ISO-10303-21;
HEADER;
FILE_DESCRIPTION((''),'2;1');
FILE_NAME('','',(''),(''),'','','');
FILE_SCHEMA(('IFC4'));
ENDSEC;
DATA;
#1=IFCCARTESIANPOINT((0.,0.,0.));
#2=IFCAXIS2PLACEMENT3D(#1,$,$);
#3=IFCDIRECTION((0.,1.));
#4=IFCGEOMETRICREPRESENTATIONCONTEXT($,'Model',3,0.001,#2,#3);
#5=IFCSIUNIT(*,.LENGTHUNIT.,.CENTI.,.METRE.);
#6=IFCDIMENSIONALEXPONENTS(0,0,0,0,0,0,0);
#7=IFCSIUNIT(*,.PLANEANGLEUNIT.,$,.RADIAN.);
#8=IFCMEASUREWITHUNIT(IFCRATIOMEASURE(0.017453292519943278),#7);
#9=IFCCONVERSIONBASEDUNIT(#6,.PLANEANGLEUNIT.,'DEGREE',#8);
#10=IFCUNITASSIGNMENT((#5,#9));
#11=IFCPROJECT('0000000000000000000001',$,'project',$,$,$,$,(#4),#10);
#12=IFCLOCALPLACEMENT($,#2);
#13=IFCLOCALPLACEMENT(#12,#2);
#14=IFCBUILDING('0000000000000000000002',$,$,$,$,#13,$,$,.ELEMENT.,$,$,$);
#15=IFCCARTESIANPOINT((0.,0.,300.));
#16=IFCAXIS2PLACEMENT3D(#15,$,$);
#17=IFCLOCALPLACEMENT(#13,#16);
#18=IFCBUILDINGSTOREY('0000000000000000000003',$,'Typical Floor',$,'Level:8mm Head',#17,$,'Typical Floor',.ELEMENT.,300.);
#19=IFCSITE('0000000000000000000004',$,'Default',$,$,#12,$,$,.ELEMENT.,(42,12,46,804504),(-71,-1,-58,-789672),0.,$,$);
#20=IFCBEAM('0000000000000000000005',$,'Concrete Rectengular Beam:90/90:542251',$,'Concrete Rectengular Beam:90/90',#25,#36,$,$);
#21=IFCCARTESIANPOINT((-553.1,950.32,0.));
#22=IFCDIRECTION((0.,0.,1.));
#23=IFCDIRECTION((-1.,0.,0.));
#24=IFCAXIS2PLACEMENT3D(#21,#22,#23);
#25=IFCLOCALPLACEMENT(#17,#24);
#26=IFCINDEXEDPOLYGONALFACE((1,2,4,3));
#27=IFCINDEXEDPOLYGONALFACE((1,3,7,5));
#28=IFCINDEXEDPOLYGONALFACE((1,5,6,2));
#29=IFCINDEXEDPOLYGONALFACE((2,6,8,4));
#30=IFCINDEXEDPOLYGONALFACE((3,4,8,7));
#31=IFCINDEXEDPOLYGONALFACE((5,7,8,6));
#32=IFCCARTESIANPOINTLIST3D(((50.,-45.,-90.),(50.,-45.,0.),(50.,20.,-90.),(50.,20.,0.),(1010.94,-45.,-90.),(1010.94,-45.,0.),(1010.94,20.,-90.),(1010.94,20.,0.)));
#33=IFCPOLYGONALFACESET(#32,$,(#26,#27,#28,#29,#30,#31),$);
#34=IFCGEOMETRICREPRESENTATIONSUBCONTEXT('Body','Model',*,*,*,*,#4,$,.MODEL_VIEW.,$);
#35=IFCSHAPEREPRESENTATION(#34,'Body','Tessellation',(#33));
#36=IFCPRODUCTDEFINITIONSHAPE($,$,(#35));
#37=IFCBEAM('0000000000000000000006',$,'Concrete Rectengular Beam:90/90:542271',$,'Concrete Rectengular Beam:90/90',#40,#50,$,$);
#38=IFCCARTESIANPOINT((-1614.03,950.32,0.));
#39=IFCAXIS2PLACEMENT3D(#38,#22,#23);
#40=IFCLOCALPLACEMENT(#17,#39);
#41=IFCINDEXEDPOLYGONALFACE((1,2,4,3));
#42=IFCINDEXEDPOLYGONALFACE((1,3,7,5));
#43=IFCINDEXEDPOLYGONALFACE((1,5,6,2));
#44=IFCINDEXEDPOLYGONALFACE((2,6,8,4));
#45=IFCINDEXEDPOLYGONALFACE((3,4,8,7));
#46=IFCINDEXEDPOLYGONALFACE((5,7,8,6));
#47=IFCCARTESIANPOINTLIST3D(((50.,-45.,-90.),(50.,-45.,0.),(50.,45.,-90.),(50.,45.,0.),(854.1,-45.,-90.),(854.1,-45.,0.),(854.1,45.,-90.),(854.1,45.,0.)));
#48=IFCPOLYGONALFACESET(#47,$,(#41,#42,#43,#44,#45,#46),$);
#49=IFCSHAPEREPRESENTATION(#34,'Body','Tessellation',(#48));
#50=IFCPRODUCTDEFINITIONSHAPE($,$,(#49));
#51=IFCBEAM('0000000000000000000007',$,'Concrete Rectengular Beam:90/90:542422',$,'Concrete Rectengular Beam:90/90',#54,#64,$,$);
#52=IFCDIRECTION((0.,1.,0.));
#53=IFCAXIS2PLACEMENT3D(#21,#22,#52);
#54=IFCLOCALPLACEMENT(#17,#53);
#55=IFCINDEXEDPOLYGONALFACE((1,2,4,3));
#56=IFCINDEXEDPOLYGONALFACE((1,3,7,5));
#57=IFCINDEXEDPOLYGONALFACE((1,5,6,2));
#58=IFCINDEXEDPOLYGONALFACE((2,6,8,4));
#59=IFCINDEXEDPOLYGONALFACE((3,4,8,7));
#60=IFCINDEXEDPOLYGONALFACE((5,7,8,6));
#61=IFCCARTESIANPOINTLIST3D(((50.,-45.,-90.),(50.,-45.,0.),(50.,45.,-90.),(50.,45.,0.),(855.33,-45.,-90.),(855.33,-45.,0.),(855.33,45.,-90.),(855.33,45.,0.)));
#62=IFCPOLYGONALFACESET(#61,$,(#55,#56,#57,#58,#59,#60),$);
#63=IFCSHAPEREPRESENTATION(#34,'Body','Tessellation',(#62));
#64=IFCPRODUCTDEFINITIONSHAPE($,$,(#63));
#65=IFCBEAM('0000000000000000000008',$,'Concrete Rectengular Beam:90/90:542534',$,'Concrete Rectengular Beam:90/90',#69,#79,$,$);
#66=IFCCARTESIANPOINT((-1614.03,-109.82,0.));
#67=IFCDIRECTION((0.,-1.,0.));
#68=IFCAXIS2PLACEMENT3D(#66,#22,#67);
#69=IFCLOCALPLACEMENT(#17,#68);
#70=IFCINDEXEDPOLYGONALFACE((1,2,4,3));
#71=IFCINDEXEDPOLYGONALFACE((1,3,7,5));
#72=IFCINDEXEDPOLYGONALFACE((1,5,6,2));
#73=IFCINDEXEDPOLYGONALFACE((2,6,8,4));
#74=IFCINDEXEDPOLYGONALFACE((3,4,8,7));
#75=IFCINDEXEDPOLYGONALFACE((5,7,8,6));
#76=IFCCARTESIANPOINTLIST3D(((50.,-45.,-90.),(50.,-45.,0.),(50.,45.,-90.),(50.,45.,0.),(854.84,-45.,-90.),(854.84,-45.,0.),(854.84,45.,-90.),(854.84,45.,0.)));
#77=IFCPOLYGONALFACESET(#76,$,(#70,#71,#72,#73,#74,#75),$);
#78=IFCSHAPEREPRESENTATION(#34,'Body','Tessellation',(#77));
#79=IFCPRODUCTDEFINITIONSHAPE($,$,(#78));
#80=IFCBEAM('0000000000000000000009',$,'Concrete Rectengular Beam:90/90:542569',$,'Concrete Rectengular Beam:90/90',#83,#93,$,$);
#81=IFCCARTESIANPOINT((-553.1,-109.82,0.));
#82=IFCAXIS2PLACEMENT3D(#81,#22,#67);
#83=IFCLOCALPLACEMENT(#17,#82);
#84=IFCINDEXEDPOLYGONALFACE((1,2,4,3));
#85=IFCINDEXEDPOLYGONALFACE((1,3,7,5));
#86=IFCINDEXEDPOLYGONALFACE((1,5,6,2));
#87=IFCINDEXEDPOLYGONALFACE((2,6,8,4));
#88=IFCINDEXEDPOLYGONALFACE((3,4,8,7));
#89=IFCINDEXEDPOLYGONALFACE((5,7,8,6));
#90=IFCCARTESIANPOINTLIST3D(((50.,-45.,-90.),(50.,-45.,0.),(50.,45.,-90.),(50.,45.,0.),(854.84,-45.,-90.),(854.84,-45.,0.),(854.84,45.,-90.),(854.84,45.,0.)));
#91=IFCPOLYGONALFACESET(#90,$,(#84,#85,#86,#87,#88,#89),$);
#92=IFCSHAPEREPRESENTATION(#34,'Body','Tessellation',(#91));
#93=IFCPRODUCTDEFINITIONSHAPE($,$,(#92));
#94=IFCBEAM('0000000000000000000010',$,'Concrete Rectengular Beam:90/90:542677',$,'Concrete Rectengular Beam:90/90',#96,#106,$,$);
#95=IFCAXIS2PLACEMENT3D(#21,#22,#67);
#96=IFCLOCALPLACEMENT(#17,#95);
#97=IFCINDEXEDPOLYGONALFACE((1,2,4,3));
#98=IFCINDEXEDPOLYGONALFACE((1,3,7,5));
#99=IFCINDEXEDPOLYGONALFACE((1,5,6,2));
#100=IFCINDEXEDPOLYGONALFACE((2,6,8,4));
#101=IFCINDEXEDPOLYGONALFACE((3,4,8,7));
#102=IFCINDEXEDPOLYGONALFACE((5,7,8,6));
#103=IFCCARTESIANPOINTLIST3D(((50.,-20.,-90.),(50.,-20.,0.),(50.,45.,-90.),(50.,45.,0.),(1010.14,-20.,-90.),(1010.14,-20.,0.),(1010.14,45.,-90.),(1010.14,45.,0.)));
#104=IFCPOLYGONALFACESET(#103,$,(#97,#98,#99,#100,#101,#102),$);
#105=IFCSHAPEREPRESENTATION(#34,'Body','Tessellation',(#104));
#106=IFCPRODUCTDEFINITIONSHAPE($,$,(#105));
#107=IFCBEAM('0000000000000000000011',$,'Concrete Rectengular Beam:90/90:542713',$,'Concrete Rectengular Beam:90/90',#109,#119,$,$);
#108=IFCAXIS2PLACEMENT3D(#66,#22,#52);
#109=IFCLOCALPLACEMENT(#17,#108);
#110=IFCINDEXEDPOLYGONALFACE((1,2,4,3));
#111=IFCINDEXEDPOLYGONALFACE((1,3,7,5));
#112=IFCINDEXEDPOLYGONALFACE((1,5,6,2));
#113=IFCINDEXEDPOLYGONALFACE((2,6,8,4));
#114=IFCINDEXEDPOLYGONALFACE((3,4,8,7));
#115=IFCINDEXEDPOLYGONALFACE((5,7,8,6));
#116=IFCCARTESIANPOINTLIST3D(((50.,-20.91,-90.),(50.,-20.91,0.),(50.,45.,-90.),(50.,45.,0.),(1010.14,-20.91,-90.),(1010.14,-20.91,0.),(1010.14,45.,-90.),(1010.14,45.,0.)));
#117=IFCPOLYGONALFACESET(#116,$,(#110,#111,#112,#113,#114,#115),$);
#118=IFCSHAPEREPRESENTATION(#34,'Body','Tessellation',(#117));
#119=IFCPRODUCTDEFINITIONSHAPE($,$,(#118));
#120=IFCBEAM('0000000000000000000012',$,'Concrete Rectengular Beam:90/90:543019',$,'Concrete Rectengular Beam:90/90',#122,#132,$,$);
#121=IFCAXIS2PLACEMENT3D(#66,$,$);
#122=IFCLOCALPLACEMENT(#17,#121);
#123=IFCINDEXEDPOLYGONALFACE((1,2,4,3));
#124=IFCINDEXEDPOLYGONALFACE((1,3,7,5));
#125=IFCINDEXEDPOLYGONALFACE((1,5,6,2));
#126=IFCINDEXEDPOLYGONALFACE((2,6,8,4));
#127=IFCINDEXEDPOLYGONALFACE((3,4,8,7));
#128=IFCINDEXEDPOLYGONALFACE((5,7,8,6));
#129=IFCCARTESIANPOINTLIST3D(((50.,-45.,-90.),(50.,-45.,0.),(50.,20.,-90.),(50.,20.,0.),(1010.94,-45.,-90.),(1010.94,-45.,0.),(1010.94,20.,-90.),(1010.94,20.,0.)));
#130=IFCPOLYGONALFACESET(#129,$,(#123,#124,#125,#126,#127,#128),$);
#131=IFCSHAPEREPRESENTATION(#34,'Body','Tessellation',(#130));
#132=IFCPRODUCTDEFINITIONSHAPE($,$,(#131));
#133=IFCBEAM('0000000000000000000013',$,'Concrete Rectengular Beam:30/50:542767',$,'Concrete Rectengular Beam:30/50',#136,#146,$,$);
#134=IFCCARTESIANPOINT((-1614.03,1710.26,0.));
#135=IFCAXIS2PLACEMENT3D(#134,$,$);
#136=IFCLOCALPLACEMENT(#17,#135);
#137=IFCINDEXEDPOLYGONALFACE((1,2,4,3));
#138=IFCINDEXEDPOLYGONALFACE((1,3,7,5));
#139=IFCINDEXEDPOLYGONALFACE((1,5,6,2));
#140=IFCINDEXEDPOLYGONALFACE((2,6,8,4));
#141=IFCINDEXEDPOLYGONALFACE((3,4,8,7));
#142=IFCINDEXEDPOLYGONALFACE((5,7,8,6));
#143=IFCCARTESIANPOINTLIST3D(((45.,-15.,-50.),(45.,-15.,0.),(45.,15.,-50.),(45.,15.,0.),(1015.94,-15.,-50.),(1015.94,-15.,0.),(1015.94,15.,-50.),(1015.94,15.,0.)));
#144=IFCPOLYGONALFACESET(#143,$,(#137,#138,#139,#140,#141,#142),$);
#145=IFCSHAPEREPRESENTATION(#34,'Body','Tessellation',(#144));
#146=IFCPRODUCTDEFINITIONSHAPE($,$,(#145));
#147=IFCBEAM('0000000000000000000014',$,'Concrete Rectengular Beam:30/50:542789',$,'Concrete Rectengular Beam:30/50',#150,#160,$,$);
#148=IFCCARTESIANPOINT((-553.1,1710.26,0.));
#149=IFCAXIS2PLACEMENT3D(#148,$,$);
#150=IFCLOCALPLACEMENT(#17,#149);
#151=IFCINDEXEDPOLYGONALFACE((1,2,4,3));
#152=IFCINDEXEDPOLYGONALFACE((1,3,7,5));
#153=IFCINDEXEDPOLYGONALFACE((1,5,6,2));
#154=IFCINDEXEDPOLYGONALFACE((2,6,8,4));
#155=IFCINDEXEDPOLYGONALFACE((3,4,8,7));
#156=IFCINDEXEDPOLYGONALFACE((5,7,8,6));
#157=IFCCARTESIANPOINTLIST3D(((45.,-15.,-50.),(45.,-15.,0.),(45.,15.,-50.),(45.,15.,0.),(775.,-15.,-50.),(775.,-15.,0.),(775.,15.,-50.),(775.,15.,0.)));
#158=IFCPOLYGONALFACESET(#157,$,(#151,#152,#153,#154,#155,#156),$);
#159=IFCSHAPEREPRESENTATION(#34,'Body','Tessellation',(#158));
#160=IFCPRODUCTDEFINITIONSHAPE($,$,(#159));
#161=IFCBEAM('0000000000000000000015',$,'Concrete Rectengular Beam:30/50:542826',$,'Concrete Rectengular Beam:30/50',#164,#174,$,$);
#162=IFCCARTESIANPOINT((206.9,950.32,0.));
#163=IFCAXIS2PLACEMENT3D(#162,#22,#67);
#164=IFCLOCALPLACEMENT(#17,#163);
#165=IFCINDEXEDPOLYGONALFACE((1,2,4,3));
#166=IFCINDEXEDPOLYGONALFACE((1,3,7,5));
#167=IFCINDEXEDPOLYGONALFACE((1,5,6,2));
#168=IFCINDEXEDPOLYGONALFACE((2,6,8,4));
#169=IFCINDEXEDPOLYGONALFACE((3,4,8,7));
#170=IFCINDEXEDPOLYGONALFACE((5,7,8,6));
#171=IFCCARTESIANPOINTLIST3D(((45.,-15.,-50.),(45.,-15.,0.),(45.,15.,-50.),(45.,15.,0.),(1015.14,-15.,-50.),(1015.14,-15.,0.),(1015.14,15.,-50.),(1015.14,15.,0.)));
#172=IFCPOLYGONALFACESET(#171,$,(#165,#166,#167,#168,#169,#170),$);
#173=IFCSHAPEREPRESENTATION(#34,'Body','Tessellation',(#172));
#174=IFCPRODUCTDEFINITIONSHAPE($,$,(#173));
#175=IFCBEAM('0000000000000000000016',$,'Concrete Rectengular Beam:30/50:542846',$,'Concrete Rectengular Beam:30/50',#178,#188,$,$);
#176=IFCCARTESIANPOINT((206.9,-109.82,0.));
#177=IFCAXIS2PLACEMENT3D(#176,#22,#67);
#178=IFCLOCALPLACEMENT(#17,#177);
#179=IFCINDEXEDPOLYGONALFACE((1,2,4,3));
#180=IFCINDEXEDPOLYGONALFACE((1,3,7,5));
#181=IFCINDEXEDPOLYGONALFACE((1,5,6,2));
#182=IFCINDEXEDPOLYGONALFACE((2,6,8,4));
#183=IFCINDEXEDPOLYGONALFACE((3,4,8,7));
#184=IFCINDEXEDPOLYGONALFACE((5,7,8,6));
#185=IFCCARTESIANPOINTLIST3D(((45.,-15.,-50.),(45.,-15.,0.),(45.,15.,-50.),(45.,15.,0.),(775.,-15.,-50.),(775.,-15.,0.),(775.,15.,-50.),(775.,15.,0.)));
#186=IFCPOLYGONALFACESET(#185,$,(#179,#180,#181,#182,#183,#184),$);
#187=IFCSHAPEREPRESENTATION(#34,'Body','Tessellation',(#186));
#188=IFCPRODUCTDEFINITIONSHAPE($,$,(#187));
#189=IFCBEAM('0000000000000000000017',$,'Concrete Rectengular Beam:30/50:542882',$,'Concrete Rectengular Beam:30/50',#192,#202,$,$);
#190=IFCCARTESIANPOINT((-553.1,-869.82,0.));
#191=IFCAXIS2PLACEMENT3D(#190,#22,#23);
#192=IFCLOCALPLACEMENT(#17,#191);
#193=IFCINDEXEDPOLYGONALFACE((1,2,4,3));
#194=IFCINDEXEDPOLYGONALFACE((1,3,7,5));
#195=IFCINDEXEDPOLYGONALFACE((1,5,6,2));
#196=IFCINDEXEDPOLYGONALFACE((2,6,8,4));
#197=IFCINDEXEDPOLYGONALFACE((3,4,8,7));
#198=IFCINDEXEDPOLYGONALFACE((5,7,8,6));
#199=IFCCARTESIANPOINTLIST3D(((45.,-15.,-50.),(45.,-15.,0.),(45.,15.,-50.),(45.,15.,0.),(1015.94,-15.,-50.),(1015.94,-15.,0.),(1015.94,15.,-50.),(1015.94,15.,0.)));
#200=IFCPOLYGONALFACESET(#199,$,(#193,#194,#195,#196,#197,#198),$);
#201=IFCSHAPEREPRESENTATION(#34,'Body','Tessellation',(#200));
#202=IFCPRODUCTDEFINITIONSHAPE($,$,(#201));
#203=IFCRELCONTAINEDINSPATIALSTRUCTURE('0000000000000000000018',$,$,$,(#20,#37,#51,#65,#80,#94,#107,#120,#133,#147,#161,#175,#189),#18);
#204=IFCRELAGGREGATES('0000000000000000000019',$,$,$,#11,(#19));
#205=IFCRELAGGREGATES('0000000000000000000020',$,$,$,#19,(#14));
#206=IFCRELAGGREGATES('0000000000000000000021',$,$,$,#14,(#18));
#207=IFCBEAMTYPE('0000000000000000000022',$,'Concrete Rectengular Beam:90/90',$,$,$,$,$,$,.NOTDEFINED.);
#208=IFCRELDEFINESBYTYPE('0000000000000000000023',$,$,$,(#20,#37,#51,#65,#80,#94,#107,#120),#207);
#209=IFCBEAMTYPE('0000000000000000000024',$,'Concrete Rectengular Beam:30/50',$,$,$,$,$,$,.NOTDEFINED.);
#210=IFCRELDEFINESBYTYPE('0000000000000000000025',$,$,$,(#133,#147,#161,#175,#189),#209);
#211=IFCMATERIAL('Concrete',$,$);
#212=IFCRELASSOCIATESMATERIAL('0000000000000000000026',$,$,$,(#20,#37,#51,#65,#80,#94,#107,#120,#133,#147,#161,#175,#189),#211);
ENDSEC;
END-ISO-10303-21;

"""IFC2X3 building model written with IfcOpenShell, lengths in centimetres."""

from ifc_helpers import new_model, entity, si_unit, converted_unit, direction, frame, frame_2d, origin, origin_2d_with_axis, place, context, subcontext, project, spatial, rectangle, extrude, material, type_object, element, save


model = new_model("IFC2X3")

# Units and contexts
model_context = context("Model", 3, precision=0.001, world=origin(), true_north=direction((0.0, 1.0)))
body_context = subcontext(model_context, "Body", "Model", "MODEL_VIEW")
ifc_project = project(units=[si_unit("LENGTHUNIT", "METRE", prefix="CENTI"), converted_unit("PLANEANGLEUNIT", "DEGREE", entity("IfcRatioMeasure", 0.017453292519943278), si_unit("PLANEANGLEUNIT", "RADIAN"), dimensions=[0, 0, 0, 0, 0, 0, 0])], contexts=[model_context])

# Site, building, storey
site_placement = place(None, origin())
site = spatial("IfcSite", under=ifc_project, at=site_placement, Name="Default", CompositionType="ELEMENT", RefLatitude=(42, 12, 46, 804504), RefLongitude=(-71, -1, -58, -789672), RefElevation=0.0)
building_placement = place(site_placement, origin())
building = spatial("IfcBuilding", under=site, at=building_placement, CompositionType="ELEMENT")
storey_placement = place(building_placement, frame((0.0, 0.0, 300.0)))
storey = spatial("IfcBuildingStorey", under=building, at=storey_placement, Name="Typical Floor", ObjectType="Level:8mm Head", LongName="Typical Floor", CompositionType="ELEMENT", Elevation=300.0)

# Beams
ifc_material = material(Name="Concrete")
beam_type_1 = type_object("IfcBeamType", Name="Concrete Rectengular Beam:90/90", PredefinedType="NOTDEFINED")
beam_1_placement = place(storey_placement, frame((-553.1, 950.32, 0.0), z_axis=(0.0, 0.0, 1.0), x_axis=(-1.0, 0.0, 0.0)))
element("IfcBeam", 1, at=beam_1_placement, inside=storey, type_object=beam_type_1, material=ifc_material, Name="Concrete Rectengular Beam:90/90:542251", ObjectType="Concrete Rectengular Beam:90/90", context=body_context, shape_type="SweptSolid", body=[
    extrude(rectangle(XDim=90.0, YDim=65.0, at=frame_2d((0.0, 0.0), x_axis=(1.0, 0.0))), frame((50.0, -12.5, -45.0), z_axis=(1.0, 0.0, 0.0), x_axis=(0.0, 0.0, -1.0)), (0.0, 0.0, 1.0), 960.94),
])
beam_2_placement = place(storey_placement, frame((-1614.03, 950.32, 0.0), z_axis=(0.0, 0.0, 1.0), x_axis=(-1.0, 0.0, 0.0)))
element("IfcBeam", 2, at=beam_2_placement, inside=storey, type_object=beam_type_1, material=ifc_material, Name="Concrete Rectengular Beam:90/90:542271", ObjectType="Concrete Rectengular Beam:90/90", context=body_context, shape_type="SweptSolid", body=[
    extrude(rectangle(XDim=90.0, YDim=90.0, at=frame_2d((0.0, 0.0), x_axis=(1.0, 0.0))), frame((50.0, 0.0, -45.0), z_axis=(1.0, 0.0, 0.0), x_axis=(0.0, 0.0, -1.0)), (0.0, 0.0, 1.0), 804.1),
])
beam_3_placement = place(storey_placement, frame((-553.1, 950.32, 0.0), z_axis=(0.0, 0.0, 1.0), x_axis=(0.0, 1.0, 0.0)))
element("IfcBeam", 3, at=beam_3_placement, inside=storey, type_object=beam_type_1, material=ifc_material, Name="Concrete Rectengular Beam:90/90:542422", ObjectType="Concrete Rectengular Beam:90/90", context=body_context, shape_type="SweptSolid", body=[
    extrude(rectangle(XDim=90.0, YDim=90.0, at=frame_2d((0.0, 0.0), x_axis=(1.0, 0.0))), frame((50.0, 0.0, -45.0), z_axis=(1.0, 0.0, 0.0), x_axis=(0.0, 0.0, -1.0)), (0.0, 0.0, 1.0), 805.33),
])
for number, where, z_axis, x_axis, name in (
    (4, (-1614.03, -109.82, 0.0), (0.0, 0.0, 1.0), (0.0, -1.0, 0.0), "Concrete Rectengular Beam:90/90:542534"),
    (5, (-553.1, -109.82, 0.0), (0.0, 0.0, 1.0), (0.0, -1.0, 0.0), "Concrete Rectengular Beam:90/90:542569"),
):
    element("IfcBeam", number, at=place(storey_placement, frame(where, z_axis=z_axis, x_axis=x_axis)), inside=storey, type_object=beam_type_1, material=ifc_material, Name=name, ObjectType="Concrete Rectengular Beam:90/90", context=body_context, shape_type="SweptSolid", body=[
        extrude(rectangle(XDim=90.0, YDim=90.0, at=frame_2d((0.0, 0.0), x_axis=(1.0, 0.0))), frame((50.0, 0.0, -45.0), z_axis=(1.0, 0.0, 0.0), x_axis=(0.0, 0.0, -1.0)), (0.0, 0.0, 1.0), 804.84),
    ])
beam_4_placement = place(storey_placement, frame((-553.1, 950.32, 0.0), z_axis=(0.0, 0.0, 1.0), x_axis=(0.0, -1.0, 0.0)))
element("IfcBeam", 6, at=beam_4_placement, inside=storey, type_object=beam_type_1, material=ifc_material, Name="Concrete Rectengular Beam:90/90:542677", ObjectType="Concrete Rectengular Beam:90/90", context=body_context, shape_type="SweptSolid", body=[
    extrude(rectangle(XDim=90.0, YDim=65.0, at=origin_2d_with_axis()), frame((50.0, 12.5, -45.0), z_axis=(1.0, 0.0, 0.0), x_axis=(0.0, 0.0, -1.0)), (0.0, 0.0, 1.0), 960.14),
])
beam_5_placement = place(storey_placement, frame((-1614.03, -109.82, 0.0), z_axis=(0.0, 0.0, 1.0), x_axis=(0.0, 1.0, 0.0)))
element("IfcBeam", 7, at=beam_5_placement, inside=storey, type_object=beam_type_1, material=ifc_material, Name="Concrete Rectengular Beam:90/90:542713", ObjectType="Concrete Rectengular Beam:90/90", context=body_context, shape_type="SweptSolid", body=[
    extrude(rectangle(XDim=90.0, YDim=65.91, at=frame_2d((0.0, 0.0), x_axis=(1.0, 0.0))), frame((50.0, 12.04, -45.0), z_axis=(1.0, 0.0, 0.0), x_axis=(0.0, 0.0, -1.0)), (0.0, 0.0, 1.0), 960.14),
])
beam_6_placement = place(storey_placement, frame((-1614.03, -109.82, 0.0)))
element("IfcBeam", 8, at=beam_6_placement, inside=storey, type_object=beam_type_1, material=ifc_material, Name="Concrete Rectengular Beam:90/90:543019", ObjectType="Concrete Rectengular Beam:90/90", context=body_context, shape_type="SweptSolid", body=[
    extrude(rectangle(XDim=90.0, YDim=65.0, at=frame_2d((0.0, 0.0), x_axis=(1.0, 0.0))), frame((50.0, -12.5, -45.0), z_axis=(1.0, 0.0, 0.0), x_axis=(0.0, 0.0, -1.0)), (0.0, 0.0, 1.0), 960.94),
])
beam_type_2 = type_object("IfcBeamType", Name="Concrete Rectengular Beam:30/50", PredefinedType="NOTDEFINED")
beam_7_placement = place(storey_placement, frame((-1614.03, 1710.26, 0.0)))
element("IfcBeam", 9, at=beam_7_placement, inside=storey, type_object=beam_type_2, material=ifc_material, Name="Concrete Rectengular Beam:30/50:542767", ObjectType="Concrete Rectengular Beam:30/50", context=body_context, shape_type="SweptSolid", body=[
    extrude(rectangle(XDim=50.0, YDim=30.0, at=frame_2d((0.0, 0.0), x_axis=(1.0, 0.0))), frame((45.0, 0.0, -25.0), z_axis=(1.0, 0.0, 0.0), x_axis=(0.0, 0.0, -1.0)), (0.0, 0.0, 1.0), 970.94),
])
beam_8_placement = place(storey_placement, frame((-553.1, 1710.26, 0.0)))
element("IfcBeam", 10, at=beam_8_placement, inside=storey, type_object=beam_type_2, material=ifc_material, Name="Concrete Rectengular Beam:30/50:542789", ObjectType="Concrete Rectengular Beam:30/50", context=body_context, shape_type="SweptSolid", body=[
    extrude(rectangle(XDim=50.0, YDim=30.0, at=frame_2d((0.0, 0.0), x_axis=(1.0, 0.0))), frame((45.0, 0.0, -25.0), z_axis=(1.0, 0.0, 0.0), x_axis=(0.0, 0.0, -1.0)), (0.0, 0.0, 1.0), 730.0),
])
beam_9_placement = place(storey_placement, frame((206.9, 950.32, 0.0), z_axis=(0.0, 0.0, 1.0), x_axis=(0.0, -1.0, 0.0)))
element("IfcBeam", 11, at=beam_9_placement, inside=storey, type_object=beam_type_2, material=ifc_material, Name="Concrete Rectengular Beam:30/50:542826", ObjectType="Concrete Rectengular Beam:30/50", context=body_context, shape_type="SweptSolid", body=[
    extrude(rectangle(XDim=50.0, YDim=30.0, at=frame_2d((0.0, 0.0), x_axis=(1.0, 0.0))), frame((45.0, 0.0, -25.0), z_axis=(1.0, 0.0, 0.0), x_axis=(0.0, 0.0, -1.0)), (0.0, 0.0, 1.0), 970.14),
])
beam_10_placement = place(storey_placement, frame((206.9, -109.82, 0.0), z_axis=(0.0, 0.0, 1.0), x_axis=(0.0, -1.0, 0.0)))
element("IfcBeam", 12, at=beam_10_placement, inside=storey, type_object=beam_type_2, material=ifc_material, Name="Concrete Rectengular Beam:30/50:542846", ObjectType="Concrete Rectengular Beam:30/50", context=body_context, shape_type="SweptSolid", body=[
    extrude(rectangle(XDim=50.0, YDim=30.0, at=origin_2d_with_axis()), frame((45.0, 0.0, -25.0), z_axis=(1.0, 0.0, 0.0), x_axis=(0.0, 0.0, -1.0)), (0.0, 0.0, 1.0), 730.0),
])
beam_11_placement = place(storey_placement, frame((-553.1, -869.82, 0.0), z_axis=(0.0, 0.0, 1.0), x_axis=(-1.0, 0.0, 0.0)))
element("IfcBeam", 13, at=beam_11_placement, inside=storey, type_object=beam_type_2, material=ifc_material, Name="Concrete Rectengular Beam:30/50:542882", ObjectType="Concrete Rectengular Beam:30/50", context=body_context, shape_type="SweptSolid", body=[
    extrude(rectangle(XDim=50.0, YDim=30.0, at=frame_2d((0.0, 0.0), x_axis=(1.0, 0.0))), frame((45.0, 0.0, -25.0), z_axis=(1.0, 0.0, 0.0), x_axis=(0.0, 0.0, -1.0)), (0.0, 0.0, 1.0), 970.94),
])

save(model, "model.ifc")
